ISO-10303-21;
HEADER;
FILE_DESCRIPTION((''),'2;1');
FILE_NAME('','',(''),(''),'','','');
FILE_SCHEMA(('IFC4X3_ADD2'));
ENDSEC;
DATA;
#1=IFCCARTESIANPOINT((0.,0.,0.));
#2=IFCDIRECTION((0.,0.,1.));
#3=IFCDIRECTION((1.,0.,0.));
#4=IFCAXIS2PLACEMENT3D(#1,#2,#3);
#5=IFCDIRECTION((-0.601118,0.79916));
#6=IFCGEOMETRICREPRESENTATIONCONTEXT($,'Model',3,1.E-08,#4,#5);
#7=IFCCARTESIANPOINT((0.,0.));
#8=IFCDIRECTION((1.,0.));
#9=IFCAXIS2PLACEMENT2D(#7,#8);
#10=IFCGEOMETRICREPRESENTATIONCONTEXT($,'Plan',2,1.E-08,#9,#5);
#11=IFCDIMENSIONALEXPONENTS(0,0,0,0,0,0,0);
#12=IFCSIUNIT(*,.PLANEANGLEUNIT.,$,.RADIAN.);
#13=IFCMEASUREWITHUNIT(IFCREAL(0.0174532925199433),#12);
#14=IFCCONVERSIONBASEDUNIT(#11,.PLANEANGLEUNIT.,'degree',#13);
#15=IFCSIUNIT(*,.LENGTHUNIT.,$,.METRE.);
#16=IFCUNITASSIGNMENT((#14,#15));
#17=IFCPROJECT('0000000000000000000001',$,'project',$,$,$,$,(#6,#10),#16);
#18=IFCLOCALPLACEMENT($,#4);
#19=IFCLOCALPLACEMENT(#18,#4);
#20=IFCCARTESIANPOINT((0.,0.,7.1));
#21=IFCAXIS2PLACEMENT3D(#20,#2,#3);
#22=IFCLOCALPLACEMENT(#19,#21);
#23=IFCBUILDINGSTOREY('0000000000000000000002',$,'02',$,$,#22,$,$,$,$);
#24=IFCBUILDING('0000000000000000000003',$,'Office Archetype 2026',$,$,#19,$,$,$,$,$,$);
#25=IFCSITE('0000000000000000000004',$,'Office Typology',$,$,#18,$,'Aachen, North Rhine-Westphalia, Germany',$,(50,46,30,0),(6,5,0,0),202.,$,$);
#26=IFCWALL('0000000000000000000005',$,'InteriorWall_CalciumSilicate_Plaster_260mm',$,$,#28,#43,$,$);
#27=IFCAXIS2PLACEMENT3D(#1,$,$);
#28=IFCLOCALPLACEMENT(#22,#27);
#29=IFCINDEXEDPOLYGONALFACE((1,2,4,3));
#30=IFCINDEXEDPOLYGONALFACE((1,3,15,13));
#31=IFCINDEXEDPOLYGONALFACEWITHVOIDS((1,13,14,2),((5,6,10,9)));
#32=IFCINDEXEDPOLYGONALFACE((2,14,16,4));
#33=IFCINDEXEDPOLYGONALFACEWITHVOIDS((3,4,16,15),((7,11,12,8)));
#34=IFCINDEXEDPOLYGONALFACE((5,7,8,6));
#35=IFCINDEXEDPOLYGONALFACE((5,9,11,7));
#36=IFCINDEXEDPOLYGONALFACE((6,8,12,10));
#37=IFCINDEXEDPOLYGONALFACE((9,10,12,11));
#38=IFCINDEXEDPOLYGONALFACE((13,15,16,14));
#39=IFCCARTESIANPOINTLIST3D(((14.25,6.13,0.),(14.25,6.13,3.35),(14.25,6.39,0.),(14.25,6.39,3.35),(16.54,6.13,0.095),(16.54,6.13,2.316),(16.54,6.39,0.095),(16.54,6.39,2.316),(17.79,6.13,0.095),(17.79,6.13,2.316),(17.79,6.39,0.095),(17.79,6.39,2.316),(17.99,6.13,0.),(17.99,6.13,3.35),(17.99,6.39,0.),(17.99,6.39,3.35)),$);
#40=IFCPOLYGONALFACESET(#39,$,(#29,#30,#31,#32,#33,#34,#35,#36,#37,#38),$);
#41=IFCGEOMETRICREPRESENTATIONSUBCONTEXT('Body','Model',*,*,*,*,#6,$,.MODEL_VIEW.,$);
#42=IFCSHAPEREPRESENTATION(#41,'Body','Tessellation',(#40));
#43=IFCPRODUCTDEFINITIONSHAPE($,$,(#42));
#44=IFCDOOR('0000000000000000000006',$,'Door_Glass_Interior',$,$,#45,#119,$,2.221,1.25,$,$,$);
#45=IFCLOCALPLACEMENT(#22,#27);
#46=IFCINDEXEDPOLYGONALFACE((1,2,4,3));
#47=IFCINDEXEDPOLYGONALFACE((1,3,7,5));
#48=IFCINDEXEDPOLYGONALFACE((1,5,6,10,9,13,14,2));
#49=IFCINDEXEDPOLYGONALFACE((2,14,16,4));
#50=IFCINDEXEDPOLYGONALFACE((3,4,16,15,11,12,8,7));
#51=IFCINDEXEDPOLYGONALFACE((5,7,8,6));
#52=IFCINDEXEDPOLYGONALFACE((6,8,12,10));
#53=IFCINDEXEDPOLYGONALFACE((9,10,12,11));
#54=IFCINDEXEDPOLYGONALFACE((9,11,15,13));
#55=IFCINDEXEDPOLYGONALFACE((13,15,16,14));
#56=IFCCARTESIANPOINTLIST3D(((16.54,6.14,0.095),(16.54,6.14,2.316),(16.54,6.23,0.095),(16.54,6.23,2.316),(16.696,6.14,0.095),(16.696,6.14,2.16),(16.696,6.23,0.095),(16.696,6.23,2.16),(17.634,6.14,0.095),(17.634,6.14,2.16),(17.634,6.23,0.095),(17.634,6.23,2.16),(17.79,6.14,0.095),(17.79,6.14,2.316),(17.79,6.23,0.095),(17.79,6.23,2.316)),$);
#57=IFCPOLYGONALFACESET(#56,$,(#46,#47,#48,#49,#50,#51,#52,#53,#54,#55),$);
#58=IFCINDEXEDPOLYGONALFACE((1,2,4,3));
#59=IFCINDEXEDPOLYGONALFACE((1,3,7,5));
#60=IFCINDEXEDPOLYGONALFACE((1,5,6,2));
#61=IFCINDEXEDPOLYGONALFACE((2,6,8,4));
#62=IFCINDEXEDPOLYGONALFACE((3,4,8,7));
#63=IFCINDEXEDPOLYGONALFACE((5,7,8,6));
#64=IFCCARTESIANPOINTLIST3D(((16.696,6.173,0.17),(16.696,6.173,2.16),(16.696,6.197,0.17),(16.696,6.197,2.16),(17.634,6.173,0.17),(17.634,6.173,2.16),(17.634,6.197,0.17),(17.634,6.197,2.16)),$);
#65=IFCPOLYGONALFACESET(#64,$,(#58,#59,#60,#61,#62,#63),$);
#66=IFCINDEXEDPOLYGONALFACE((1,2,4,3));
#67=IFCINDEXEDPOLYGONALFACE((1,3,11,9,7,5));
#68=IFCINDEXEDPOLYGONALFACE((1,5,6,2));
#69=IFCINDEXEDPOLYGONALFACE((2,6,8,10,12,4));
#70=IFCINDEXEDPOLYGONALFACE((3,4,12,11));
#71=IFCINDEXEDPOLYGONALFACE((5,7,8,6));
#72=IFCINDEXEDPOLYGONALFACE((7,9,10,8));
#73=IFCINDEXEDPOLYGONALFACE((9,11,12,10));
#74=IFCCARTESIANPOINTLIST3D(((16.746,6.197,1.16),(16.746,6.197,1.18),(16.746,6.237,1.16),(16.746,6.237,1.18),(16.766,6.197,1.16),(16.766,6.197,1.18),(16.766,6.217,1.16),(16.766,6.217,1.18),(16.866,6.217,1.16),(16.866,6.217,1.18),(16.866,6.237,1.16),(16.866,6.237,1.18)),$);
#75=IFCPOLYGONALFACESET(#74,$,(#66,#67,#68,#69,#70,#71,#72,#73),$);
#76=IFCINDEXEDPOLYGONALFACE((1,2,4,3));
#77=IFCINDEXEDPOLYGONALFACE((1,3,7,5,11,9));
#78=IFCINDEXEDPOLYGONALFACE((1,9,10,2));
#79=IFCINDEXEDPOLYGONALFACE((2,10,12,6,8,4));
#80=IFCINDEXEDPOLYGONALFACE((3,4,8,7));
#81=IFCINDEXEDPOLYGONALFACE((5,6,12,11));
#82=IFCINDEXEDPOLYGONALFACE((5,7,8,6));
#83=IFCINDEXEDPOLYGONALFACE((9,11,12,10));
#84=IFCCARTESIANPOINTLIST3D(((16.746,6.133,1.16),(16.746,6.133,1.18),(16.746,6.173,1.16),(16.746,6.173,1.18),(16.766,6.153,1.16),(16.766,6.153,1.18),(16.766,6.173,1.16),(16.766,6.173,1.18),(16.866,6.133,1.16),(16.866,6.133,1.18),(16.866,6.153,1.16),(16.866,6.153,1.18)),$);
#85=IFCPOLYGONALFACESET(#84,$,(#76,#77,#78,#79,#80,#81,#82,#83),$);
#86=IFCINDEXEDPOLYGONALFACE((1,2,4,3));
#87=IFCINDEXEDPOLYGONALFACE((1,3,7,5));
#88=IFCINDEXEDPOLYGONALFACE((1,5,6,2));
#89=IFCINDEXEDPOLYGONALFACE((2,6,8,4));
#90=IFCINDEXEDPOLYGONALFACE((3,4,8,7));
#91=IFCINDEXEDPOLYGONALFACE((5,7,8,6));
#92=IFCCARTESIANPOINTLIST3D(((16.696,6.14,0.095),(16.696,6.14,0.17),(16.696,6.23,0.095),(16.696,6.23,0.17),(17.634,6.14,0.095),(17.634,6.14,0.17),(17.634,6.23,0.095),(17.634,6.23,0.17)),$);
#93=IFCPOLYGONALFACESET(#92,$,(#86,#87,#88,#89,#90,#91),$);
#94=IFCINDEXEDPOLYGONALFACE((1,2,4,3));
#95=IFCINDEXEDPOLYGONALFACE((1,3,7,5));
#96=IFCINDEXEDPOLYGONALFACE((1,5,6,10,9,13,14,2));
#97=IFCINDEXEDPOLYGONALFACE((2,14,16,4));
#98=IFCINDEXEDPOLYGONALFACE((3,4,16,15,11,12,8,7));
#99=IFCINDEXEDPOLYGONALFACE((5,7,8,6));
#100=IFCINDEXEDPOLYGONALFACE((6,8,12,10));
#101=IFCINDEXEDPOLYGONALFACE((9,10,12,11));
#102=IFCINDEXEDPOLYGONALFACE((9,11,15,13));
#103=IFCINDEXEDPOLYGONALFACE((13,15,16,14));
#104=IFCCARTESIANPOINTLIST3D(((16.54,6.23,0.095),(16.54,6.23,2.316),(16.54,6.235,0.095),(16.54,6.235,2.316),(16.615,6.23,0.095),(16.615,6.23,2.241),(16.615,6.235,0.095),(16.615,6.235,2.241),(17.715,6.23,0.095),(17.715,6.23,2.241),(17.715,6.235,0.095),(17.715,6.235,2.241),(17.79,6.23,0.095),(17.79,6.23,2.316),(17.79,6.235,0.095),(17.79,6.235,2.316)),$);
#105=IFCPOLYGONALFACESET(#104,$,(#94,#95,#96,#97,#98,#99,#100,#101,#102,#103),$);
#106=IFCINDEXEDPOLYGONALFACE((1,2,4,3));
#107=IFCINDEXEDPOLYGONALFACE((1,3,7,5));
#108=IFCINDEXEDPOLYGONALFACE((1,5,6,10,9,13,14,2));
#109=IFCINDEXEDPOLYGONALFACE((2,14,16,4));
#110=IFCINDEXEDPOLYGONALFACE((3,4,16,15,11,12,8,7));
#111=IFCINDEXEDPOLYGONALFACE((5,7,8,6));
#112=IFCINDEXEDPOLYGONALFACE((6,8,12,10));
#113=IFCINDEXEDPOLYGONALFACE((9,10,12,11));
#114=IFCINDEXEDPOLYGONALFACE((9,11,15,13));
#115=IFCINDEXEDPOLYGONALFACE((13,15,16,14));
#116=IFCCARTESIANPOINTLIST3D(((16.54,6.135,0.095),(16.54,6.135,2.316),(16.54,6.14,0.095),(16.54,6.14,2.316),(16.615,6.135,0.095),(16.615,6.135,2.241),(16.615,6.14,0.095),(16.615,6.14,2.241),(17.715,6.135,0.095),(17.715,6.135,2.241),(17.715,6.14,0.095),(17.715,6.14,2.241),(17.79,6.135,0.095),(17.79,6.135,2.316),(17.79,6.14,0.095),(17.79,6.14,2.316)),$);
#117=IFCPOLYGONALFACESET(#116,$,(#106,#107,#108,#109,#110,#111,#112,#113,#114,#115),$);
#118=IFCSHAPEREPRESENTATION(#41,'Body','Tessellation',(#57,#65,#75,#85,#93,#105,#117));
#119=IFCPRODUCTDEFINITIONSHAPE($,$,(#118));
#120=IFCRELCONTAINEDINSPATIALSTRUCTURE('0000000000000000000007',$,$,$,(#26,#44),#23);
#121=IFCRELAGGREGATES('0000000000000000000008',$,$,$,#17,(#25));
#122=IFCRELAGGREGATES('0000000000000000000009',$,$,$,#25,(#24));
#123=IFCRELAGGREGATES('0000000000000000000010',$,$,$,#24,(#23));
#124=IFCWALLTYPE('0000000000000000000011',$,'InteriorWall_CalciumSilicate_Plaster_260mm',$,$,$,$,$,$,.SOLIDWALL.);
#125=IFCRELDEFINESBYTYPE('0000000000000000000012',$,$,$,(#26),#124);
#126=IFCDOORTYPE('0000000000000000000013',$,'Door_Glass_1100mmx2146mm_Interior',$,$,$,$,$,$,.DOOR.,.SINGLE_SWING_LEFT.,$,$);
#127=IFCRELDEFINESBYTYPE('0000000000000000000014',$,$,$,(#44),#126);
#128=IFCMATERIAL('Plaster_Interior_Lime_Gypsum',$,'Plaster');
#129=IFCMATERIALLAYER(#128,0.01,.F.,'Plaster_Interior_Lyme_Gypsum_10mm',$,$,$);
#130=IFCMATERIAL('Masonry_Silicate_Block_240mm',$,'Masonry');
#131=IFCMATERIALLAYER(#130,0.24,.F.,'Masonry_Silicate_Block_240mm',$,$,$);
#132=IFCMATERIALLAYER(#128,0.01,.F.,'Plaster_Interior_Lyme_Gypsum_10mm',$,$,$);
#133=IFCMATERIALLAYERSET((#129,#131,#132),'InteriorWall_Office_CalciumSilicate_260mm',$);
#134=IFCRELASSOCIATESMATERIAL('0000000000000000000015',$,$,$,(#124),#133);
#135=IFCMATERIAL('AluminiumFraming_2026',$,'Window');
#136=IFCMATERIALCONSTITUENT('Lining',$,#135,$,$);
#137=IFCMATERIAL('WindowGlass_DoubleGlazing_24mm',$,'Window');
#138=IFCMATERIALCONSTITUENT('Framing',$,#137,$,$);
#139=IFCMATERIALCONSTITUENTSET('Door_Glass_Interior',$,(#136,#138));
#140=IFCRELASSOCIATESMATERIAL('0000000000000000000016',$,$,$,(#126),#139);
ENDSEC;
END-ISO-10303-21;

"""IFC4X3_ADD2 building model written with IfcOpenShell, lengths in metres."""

from ifc_helpers import new_model, entity, si_unit, converted_unit, direction, frame, origin_with_axes, origin_2d_with_axis, place, context, subcontext, project, spatial, line, indexed_curve, outline, extrude, source, transform, mapped, material, layer, layer_set, constituent, constituent_set, type_object, type_shapes, element, fill, save


model = new_model("IFC4X3_ADD2")

# Units and contexts
model_context = context("Model", 3, precision=1e-08, world=origin_with_axes(), true_north=direction((-0.601118, 0.79916)))
plan_context = context("Plan", 2, precision=1e-08, world=origin_2d_with_axis(), true_north=direction((-0.601118, 0.79916)))
body_context = subcontext(model_context, "Body", "Model", "MODEL_VIEW")
ifc_project = project(units=[converted_unit("PLANEANGLEUNIT", "degree", entity("IfcReal", 0.0174532925199433), si_unit("PLANEANGLEUNIT", "RADIAN"), dimensions=[0, 0, 0, 0, 0, 0, 0]), si_unit("LENGTHUNIT", "METRE")], contexts=[model_context, plan_context])

# Site, building, storey
site_placement = place(None, origin_with_axes())
site = spatial("IfcSite", under=ifc_project, at=site_placement, Name="Office Typology", LongName="Aachen, North Rhine-Westphalia, Germany", RefLatitude=(50, 46, 30, 0), RefLongitude=(6, 5, 0, 0), RefElevation=202.0)
building_placement = place(site_placement, origin_with_axes())
building = spatial("IfcBuilding", under=site, at=building_placement, Name="Office Archetype 2026")
storey_placement = place(building_placement, frame((0.0, 0.0, 7.1), z_axis=(0.0, 0.0, 1.0), x_axis=(1.0, 0.0, 0.0)))
storey = spatial("IfcBuildingStorey", under=building, at=storey_placement, Name="02")

# Shared definitions
ifc_material_1 = material(Name="Plaster_Interior_Lime_Gypsum", Category="Plaster")
ifc_layer_1 = layer(ifc_material_1, 0.01, ventilated=False, Name="Plaster_Interior_Lyme_Gypsum_10mm")
ifc_material_2 = material(Name="Masonry_Silicate_Block_240mm", Category="Masonry")
ifc_layer_2 = layer(ifc_material_2, 0.24, ventilated=False, Name="Masonry_Silicate_Block_240mm")
ifc_layer_3 = layer(ifc_material_1, 0.01, ventilated=False, Name="Plaster_Interior_Lyme_Gypsum_10mm")
ifc_layer_set_1 = layer_set([ifc_layer_1, ifc_layer_2, ifc_layer_3], Name="InteriorWall_Office_CalciumSilicate_260mm")
wall_type_1 = type_object("IfcWallType", Name="InteriorWall_CalciumSilicate_Plaster_260mm", PredefinedType="SOLIDWALL", material=ifc_layer_set_1)

# Wall, opening, door
wall_1_placement = place(storey_placement, frame((18.25, 6.39, 0.0), z_axis=(0.0, 0.0, 1.0), x_axis=(-1.0, 0.0, 0.0)))
wall_1 = element("IfcWall", 1, at=wall_1_placement, inside=storey, type_object=wall_type_1, Name="InteriorWall_CalciumSilicate_Plaster_260mm", context=body_context, shape_type="SweptSolid", body=[
    extrude(outline(indexed_curve([(0.26, 0.0), (0.26, 0.26), (4.0, 0.26), (4.0, 0.0)], segments=[line(1, 2, 3, 4, 1)])), origin_with_axes(), (0.0, 0.0, 1.0), 3.35),
])
shared_shape_1 = source(origin_with_axes(), body_context, "Body", "SweptSolid", [
    extrude(outline(indexed_curve([(0.0, 2.221), (1.25, 2.221), (1.25, 0.0), (0.0, 0.0), (0.0, 2.221)])), frame((0.0, -0.16, 0.0), z_axis=(0.0, -1.0, 0.0), x_axis=(1.0, 0.0, 0.0)), (0.0, 0.0, -1.0), 0.26),
])
opening_1_placement = place(wall_1_placement, frame((0.46, 0.16, 0.095), z_axis=(0.0, 0.0, 1.0), x_axis=(1.0, 0.0, 0.0)))
opening_1 = element("IfcOpeningElement", 2, at=opening_1_placement, cuts=wall_1, PredefinedType="OPENING", context=body_context, shape_type="MappedRepresentation", body=[
    mapped(shared_shape_1, transform((0.0, 0.0, 0.0), x_axis=(1.0, 0.0, 0.0), y_axis=(0.0, 1.0, 0.0), z_axis=(0.0, 0.0, 1.0), scale=1.0)),
])
ifc_material_3 = material(Name="AluminiumFraming_2026", Category="Window")
ifc_constituent_1 = constituent(ifc_material_3, Name="Lining")
ifc_material_4 = material(Name="WindowGlass_DoubleGlazing_24mm", Category="Window")
ifc_constituent_2 = constituent(ifc_material_4, Name="Framing")
ifc_constituent_set_1 = constituent_set(constituents=[ifc_constituent_1, ifc_constituent_2], Name="Door_Glass_Interior")
door_type_1 = type_object("IfcDoorType", Name="Door_Glass_1100mmx2146mm_Interior", OperationType="SINGLE_SWING_LEFT", PredefinedType="DOOR", material=ifc_constituent_set_1)
shared_shape_2 = source(origin_with_axes(), body_context, "Body", "SweptSolid", [
    extrude(outline(indexed_curve([(0.0, 0.0), (0.0, 2.221), (1.25, 2.221), (1.25, 0.0), (1.094, 0.0), (1.094, 2.065), (0.156, 2.065), (0.156, 0.0)], segments=[line(1, 2, 3, 4, 5, 6, 7, 8, 1)])), frame((0.0, 0.0, 0.0), z_axis=(0.0, -1.0, 0.0), x_axis=(1.0, 0.0, 0.0)), (0.0, 0.0, -1.0), 0.09),
    extrude(outline(indexed_curve([(0.0, 0.0), (0.938, 0.0), (0.938, 0.024), (0.0, 0.024)], segments=[line(1, 2, 3, 4, 1)])), frame((0.156, 0.033, 0.075), z_axis=(0.0, 0.0, 1.0), x_axis=(1.0, 0.0, 0.0)), (0.0, 0.0, 1.0), 1.99),
    extrude(outline(indexed_curve([(0.0, 0.0), (0.0, -0.04), (-0.12, -0.04), (-0.12, -0.02), (-0.02, -0.02), (-0.02, 0.0)], segments=[line(1, 2, 3, 4, 5, 6, 1)])), frame((1.044, 0.033, 1.065), z_axis=(0.0, 0.0, 1.0), x_axis=(1.0, 0.0, 0.0)), (0.0, 0.0, 1.0), 0.02),
    extrude(outline(indexed_curve([(0.0, 0.0), (0.0, 0.04), (-0.12, 0.04), (-0.12, 0.02), (-0.02, 0.02), (-0.02, 0.0)], segments=[line(1, 2, 3, 4, 5, 6, 1)])), frame((1.044, 0.057, 1.065), z_axis=(0.0, 0.0, 1.0), x_axis=(1.0, 0.0, 0.0)), (0.0, 0.0, 1.0), 0.02),
    extrude(outline(indexed_curve([(0.0, 0.0), (0.938, 0.0), (0.938, 0.09), (0.0, 0.09)], segments=[line(1, 2, 3, 4, 1)])), frame((0.156, 0.0, 0.0), z_axis=(0.0, 0.0, 1.0), x_axis=(1.0, 0.0, 0.0)), (0.0, 0.0, 1.0), 0.075),
    extrude(outline(indexed_curve([(0.0, 0.0), (0.0, 2.221), (1.25, 2.221), (1.25, 0.0), (1.175, 0.0), (1.175, 2.146), (0.075, 2.146), (0.075, 0.0)], segments=[line(1, 2, 3, 4, 5, 6, 7, 8, 1)])), frame((0.0, -0.005, 0.0), z_axis=(0.0, -1.0, 0.0), x_axis=(1.0, 0.0, 0.0)), (0.0, 0.0, -1.0), 0.005),
    extrude(outline(indexed_curve([(0.0, 0.0), (0.0, 2.221), (1.25, 2.221), (1.25, 0.0), (1.175, 0.0), (1.175, 2.146), (0.075, 2.146), (0.075, 0.0)], segments=[line(1, 2, 3, 4, 5, 6, 7, 8, 1)])), frame((0.0, 0.09, 0.0), z_axis=(0.0, -1.0, 0.0), x_axis=(1.0, 0.0, 0.0)), (0.0, 0.0, -1.0), 0.005),
])
type_shapes(door_type_1, [shared_shape_2])
door_1_placement = place(opening_1_placement, origin_with_axes())
door_1 = element("IfcDoor", 3, at=door_1_placement, inside=storey, type_object=door_type_1, Name="Door_Glass_Interior", OverallHeight=2.221, OverallWidth=1.25, context=body_context, shape_type="MappedRepresentation", body=[
    mapped(shared_shape_2, transform((0.0, 0.0, 0.0), x_axis=(1.0, 0.0, 0.0), y_axis=(0.0, 1.0, 0.0), z_axis=(0.0, 0.0, 1.0), scale=1.0)),
])
fill(opening_1, door_1)

save(model, "model.ifc")
